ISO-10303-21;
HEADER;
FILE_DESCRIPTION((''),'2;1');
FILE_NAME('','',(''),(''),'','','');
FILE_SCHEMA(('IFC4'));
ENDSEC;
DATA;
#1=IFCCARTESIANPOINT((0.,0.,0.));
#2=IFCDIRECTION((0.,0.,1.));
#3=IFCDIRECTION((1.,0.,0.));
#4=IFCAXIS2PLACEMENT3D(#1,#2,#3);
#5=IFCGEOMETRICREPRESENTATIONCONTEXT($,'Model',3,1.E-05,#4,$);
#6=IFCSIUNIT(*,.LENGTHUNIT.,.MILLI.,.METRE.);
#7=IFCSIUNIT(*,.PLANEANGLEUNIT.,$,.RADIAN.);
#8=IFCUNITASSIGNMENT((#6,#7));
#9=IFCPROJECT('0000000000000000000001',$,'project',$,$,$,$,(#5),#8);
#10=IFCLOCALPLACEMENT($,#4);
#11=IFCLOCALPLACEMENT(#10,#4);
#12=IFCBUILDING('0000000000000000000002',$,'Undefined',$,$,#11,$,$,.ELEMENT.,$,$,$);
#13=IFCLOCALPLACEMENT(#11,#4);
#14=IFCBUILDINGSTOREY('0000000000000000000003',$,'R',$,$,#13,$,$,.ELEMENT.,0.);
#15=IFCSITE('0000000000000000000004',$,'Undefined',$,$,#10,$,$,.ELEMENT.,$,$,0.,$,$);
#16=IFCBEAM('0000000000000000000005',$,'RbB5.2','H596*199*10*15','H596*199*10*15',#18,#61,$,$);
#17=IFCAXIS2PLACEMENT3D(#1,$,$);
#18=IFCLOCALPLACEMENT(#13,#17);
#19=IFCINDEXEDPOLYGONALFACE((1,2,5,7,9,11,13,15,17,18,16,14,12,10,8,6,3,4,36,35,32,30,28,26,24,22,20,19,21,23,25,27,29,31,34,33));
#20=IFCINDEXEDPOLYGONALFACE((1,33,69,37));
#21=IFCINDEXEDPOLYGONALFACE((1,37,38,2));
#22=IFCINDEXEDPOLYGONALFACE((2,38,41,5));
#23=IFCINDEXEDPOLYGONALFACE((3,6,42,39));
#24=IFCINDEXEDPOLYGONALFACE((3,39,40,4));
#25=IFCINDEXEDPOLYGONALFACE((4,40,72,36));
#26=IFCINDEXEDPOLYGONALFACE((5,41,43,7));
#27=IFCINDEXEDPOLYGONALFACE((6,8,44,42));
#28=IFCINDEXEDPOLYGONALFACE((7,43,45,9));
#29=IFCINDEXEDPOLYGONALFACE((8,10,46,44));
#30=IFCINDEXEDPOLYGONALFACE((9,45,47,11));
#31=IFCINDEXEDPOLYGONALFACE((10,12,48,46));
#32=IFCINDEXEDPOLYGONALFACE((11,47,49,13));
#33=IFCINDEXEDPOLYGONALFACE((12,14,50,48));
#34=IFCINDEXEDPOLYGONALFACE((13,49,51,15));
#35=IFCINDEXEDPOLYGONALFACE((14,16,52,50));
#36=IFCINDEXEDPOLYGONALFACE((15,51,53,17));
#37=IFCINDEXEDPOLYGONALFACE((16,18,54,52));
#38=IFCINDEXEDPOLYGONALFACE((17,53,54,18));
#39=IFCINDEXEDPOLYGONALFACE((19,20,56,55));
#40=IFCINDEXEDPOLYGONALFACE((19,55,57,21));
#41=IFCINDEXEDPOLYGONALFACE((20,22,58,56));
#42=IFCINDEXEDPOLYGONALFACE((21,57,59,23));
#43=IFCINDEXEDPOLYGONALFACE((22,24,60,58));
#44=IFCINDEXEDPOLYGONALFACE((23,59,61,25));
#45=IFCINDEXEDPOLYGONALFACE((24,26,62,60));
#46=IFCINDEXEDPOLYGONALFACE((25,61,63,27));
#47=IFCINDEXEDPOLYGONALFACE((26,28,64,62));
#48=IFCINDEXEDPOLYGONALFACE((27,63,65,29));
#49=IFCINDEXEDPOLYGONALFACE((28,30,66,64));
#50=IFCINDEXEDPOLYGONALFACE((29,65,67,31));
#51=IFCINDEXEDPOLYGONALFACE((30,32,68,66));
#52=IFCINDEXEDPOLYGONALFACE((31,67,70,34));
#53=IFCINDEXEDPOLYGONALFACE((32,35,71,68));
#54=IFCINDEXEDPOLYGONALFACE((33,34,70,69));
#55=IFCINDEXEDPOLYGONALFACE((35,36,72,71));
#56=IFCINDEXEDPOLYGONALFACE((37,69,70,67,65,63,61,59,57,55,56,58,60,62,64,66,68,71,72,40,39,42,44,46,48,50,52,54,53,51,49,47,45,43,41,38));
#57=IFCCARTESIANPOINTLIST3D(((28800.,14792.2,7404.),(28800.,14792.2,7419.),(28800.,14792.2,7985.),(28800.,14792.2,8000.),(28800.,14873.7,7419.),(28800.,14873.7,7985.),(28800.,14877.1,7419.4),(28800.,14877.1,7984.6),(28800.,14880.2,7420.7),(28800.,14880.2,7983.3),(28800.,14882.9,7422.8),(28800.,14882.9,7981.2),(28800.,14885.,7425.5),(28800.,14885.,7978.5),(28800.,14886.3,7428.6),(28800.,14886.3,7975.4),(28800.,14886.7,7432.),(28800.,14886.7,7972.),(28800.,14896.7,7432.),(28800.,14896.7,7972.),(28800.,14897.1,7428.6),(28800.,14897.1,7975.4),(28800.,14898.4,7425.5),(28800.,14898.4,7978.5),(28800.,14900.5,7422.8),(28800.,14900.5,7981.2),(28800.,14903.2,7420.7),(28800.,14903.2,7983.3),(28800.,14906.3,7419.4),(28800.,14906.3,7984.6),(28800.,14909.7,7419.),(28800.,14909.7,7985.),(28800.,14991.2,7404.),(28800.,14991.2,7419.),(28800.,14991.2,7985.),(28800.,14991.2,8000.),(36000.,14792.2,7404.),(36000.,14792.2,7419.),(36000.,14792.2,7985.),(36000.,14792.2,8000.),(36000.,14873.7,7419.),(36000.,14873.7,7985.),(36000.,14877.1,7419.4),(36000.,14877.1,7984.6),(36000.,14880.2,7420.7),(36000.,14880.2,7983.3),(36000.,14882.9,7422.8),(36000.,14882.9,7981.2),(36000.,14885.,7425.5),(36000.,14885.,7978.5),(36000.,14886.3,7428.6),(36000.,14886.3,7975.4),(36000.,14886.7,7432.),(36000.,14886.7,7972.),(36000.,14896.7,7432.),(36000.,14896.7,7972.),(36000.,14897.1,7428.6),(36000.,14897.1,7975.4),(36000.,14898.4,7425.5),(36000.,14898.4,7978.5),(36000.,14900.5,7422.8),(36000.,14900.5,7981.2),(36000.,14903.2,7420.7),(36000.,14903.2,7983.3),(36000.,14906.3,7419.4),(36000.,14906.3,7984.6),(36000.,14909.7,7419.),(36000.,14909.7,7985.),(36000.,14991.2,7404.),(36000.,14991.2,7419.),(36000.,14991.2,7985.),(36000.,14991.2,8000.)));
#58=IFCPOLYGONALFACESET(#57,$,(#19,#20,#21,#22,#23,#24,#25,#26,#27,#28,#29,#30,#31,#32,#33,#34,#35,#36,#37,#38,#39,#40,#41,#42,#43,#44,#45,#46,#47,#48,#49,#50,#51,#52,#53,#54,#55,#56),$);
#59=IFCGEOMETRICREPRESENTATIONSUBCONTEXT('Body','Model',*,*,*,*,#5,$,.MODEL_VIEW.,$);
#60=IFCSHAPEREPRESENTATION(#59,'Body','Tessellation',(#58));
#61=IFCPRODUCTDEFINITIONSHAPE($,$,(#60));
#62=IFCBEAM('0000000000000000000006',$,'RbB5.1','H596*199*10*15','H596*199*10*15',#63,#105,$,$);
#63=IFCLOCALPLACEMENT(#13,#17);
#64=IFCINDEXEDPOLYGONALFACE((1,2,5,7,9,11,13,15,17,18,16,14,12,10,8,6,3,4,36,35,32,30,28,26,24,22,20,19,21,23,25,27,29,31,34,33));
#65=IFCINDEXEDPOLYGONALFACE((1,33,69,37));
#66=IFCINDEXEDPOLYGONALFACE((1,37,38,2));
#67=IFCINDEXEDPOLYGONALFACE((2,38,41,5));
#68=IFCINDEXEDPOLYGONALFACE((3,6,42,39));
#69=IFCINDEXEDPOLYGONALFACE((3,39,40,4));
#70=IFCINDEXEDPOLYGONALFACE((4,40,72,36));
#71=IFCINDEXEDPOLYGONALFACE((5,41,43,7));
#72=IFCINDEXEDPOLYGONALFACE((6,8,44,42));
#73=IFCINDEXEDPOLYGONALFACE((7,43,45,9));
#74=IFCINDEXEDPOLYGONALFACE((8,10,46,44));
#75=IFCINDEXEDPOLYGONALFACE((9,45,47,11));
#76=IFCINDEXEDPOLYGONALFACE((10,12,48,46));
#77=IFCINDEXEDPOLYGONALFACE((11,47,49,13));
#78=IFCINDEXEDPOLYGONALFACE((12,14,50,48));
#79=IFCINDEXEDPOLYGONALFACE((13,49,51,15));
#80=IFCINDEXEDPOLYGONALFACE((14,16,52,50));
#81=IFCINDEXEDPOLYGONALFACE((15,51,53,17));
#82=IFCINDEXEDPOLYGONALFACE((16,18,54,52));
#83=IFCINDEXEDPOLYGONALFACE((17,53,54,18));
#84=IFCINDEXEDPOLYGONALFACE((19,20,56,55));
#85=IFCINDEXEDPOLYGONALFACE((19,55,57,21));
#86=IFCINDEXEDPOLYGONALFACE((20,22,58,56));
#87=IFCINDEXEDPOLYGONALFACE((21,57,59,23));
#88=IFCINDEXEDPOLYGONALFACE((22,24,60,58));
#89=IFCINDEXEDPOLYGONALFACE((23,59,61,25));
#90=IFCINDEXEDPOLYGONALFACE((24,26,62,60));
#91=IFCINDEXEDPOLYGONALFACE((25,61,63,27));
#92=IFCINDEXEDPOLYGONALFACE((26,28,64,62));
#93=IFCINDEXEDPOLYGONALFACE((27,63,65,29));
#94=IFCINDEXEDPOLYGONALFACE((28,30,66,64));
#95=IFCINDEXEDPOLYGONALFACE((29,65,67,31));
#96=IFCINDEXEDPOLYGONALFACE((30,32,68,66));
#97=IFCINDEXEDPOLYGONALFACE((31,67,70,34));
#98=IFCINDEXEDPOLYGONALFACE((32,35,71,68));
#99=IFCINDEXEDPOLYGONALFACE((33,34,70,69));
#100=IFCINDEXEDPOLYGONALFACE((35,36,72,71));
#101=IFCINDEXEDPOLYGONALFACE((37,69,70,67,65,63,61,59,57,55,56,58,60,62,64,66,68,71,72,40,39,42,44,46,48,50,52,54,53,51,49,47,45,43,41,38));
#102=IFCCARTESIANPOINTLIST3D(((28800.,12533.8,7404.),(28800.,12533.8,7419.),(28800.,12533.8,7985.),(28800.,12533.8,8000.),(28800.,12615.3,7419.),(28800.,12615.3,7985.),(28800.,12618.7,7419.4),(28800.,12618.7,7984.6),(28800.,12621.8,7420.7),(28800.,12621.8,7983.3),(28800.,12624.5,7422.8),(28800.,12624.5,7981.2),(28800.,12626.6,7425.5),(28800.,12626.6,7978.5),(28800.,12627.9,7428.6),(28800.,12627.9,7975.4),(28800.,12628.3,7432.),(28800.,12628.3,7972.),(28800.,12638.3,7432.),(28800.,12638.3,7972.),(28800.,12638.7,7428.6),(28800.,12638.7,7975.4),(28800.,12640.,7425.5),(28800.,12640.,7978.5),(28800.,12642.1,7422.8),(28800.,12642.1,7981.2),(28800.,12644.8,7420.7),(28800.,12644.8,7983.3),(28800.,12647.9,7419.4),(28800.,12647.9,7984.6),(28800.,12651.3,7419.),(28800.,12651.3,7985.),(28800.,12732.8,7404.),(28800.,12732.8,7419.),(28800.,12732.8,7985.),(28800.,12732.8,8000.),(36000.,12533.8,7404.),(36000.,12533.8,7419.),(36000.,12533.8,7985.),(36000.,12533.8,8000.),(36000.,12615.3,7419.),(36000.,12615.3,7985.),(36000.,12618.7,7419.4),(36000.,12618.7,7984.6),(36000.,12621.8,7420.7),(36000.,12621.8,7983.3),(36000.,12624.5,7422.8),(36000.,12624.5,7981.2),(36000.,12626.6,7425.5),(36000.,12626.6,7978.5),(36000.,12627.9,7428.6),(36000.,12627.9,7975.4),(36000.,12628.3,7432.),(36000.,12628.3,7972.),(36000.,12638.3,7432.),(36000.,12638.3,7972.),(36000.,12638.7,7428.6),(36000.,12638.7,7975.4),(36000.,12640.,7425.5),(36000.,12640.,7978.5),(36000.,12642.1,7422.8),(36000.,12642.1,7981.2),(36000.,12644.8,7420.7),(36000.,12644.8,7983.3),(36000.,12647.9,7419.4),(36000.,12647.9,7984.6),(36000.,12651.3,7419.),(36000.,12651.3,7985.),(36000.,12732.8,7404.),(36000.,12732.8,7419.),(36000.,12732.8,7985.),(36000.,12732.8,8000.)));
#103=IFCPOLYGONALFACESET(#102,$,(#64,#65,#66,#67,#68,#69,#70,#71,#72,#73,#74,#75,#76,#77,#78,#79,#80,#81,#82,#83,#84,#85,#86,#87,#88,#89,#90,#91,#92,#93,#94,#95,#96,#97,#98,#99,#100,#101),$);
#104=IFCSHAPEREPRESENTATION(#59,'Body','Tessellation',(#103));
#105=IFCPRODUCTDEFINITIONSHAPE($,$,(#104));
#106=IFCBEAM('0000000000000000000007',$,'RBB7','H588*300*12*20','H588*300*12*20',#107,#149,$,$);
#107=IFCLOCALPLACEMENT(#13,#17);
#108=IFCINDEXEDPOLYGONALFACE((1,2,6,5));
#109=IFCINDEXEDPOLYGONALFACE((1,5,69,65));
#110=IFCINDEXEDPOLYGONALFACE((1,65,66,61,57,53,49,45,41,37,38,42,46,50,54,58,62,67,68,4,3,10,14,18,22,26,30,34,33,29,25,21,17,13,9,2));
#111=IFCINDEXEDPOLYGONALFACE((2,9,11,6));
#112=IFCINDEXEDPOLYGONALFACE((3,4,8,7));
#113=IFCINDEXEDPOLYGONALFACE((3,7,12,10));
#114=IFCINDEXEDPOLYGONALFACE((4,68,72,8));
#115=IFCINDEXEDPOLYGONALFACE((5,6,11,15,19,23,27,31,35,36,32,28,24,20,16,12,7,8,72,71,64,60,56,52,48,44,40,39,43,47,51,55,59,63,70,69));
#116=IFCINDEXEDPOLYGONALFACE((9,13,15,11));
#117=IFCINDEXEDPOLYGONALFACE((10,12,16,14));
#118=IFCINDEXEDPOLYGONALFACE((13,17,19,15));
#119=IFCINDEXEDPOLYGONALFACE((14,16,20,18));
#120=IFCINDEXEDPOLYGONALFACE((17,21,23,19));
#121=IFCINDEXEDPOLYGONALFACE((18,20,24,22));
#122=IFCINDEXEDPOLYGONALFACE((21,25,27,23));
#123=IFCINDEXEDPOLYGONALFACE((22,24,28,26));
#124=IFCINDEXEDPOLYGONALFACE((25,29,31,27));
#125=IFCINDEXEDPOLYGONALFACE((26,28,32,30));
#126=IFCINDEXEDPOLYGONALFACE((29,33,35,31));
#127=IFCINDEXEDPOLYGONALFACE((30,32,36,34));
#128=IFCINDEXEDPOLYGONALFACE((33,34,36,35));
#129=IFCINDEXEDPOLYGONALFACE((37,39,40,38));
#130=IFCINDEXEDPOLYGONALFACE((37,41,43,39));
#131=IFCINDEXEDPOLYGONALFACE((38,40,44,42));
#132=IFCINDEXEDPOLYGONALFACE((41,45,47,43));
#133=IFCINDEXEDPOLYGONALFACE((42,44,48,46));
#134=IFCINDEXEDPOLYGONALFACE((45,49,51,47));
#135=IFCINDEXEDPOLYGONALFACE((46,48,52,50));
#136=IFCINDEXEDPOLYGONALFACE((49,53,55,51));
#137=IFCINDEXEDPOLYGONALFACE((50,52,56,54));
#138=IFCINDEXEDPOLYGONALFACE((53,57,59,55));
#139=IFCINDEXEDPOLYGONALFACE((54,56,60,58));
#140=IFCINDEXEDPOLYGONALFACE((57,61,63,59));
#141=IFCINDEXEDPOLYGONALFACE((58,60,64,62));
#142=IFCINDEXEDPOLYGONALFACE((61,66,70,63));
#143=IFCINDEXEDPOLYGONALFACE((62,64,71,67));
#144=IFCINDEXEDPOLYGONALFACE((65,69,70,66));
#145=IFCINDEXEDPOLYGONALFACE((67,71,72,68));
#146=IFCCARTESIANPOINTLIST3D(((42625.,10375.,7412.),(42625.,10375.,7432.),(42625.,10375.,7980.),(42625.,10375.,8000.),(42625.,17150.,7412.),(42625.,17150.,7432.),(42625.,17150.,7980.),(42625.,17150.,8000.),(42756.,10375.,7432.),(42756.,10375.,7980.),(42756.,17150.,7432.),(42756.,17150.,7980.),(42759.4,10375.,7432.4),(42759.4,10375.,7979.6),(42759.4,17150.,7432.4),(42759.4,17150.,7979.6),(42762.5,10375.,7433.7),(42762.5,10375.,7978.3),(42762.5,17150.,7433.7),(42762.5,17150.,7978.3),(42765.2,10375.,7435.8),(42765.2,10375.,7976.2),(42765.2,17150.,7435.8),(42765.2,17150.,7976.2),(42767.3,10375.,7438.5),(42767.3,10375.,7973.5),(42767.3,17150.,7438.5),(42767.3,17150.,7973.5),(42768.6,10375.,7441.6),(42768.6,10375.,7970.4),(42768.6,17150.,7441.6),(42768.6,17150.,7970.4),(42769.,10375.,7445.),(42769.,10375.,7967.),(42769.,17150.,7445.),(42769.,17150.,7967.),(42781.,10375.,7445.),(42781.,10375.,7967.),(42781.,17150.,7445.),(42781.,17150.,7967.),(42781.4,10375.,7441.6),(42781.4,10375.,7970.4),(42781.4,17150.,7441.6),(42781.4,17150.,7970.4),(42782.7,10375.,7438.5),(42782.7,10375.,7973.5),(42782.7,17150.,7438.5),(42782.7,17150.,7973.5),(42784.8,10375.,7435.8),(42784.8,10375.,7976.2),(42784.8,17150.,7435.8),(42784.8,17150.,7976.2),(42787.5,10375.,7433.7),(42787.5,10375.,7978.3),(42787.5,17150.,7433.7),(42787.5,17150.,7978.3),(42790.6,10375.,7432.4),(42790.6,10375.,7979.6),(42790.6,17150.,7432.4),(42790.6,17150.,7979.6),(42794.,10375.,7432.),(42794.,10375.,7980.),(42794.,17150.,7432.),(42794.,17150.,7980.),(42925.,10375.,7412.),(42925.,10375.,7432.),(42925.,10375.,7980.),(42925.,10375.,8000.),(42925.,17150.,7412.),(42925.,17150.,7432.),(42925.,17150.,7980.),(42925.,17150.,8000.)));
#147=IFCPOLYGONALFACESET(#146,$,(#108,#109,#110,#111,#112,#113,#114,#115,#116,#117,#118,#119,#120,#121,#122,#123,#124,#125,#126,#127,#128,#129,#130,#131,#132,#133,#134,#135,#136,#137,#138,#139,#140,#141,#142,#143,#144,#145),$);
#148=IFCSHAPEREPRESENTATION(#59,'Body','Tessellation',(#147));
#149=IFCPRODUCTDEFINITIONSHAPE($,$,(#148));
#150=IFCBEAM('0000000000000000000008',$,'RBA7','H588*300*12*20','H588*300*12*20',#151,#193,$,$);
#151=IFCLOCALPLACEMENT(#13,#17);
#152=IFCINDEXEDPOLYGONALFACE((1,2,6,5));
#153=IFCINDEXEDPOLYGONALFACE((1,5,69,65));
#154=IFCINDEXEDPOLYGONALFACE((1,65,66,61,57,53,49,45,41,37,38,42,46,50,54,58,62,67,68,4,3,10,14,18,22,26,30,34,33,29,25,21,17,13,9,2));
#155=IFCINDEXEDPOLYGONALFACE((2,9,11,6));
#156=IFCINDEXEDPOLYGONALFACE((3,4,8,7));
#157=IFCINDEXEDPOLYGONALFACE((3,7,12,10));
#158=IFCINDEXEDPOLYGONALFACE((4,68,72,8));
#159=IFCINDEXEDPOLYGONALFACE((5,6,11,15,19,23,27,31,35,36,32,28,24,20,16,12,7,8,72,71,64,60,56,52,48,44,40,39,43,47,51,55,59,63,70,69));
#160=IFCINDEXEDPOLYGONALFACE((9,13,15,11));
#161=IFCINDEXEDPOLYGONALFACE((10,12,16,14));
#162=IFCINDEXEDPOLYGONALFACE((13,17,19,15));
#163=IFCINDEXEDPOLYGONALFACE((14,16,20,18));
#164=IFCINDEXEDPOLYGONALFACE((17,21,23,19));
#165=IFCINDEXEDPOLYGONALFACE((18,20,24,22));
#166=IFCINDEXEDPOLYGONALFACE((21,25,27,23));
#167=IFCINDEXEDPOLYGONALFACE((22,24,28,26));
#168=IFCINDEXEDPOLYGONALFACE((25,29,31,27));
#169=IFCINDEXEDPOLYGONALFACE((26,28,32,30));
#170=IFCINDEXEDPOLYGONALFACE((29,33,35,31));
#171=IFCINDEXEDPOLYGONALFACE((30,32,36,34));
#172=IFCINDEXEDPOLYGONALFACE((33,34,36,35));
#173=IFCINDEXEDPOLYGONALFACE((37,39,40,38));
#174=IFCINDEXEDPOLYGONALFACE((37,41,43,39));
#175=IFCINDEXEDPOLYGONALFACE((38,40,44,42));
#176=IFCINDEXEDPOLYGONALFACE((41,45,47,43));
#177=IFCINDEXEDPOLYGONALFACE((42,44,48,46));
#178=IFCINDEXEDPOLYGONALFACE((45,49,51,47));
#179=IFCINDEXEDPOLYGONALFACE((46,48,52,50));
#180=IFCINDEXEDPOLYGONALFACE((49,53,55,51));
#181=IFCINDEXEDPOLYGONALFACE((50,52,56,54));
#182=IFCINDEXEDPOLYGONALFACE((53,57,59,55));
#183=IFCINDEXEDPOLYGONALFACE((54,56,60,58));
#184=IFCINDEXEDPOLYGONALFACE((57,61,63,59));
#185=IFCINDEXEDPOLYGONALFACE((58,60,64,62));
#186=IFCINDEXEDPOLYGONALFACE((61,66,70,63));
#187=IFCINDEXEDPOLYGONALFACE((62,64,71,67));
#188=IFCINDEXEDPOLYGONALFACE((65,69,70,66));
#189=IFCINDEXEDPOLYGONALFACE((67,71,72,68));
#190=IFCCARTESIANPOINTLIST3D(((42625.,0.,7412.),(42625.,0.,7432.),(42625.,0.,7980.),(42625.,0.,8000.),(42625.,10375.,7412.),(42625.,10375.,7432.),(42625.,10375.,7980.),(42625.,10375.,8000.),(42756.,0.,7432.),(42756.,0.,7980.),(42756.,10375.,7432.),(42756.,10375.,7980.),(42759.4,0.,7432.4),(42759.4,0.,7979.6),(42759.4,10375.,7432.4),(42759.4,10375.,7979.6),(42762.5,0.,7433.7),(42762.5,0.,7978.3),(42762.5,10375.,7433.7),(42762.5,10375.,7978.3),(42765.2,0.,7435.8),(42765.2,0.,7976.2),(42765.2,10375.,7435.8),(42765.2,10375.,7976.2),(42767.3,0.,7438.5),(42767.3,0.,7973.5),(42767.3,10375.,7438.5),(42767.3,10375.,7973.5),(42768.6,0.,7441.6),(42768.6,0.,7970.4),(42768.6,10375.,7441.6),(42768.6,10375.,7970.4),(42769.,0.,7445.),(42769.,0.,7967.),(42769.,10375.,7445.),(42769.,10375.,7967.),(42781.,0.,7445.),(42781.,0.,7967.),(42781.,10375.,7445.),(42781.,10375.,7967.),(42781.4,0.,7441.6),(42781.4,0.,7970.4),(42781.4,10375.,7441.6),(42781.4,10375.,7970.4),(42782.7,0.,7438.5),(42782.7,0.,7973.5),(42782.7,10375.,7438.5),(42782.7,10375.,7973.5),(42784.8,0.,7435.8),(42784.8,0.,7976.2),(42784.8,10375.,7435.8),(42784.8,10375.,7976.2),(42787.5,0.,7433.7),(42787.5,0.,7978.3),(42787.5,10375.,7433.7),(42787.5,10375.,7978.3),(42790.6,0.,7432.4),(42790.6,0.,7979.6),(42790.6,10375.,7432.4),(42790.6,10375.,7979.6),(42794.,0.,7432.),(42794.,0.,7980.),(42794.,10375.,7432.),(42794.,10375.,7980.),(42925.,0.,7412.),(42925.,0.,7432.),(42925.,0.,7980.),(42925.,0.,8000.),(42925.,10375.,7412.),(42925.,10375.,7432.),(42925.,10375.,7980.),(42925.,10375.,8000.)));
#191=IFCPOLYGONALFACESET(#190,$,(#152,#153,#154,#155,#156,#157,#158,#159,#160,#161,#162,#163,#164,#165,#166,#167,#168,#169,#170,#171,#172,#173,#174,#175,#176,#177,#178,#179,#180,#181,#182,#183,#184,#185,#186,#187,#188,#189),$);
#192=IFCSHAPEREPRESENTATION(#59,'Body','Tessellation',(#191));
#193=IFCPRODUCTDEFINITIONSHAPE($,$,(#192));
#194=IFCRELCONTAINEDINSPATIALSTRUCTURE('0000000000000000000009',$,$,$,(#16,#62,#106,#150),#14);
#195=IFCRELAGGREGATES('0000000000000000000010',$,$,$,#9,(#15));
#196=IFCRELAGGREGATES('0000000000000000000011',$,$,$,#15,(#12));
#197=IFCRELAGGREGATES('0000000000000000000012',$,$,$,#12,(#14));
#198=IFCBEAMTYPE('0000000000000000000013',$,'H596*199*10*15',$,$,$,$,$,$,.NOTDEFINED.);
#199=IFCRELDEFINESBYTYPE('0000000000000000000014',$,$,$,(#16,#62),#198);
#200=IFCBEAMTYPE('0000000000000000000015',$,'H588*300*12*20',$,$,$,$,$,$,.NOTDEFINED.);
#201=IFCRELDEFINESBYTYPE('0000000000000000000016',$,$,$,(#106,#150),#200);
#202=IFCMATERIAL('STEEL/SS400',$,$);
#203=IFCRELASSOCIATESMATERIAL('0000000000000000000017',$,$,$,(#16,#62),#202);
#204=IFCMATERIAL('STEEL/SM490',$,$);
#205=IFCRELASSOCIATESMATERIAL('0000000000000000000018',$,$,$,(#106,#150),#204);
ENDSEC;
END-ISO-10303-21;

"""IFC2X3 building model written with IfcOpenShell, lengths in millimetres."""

from ifc_helpers import new_model, si_unit, frame, origin_with_axes, origin_2d_with_axis, place, context, subcontext, project, spatial, i_section, extrude, material, type_object, element, save


model = new_model("IFC2X3")

# Units and contexts
model_context = context("Model", 3, precision=1e-05, world=origin_with_axes())
body_context = subcontext(model_context, "Body", "Model", "MODEL_VIEW")
ifc_project = project(units=[si_unit("LENGTHUNIT", "METRE", prefix="MILLI"), si_unit("PLANEANGLEUNIT", "RADIAN")], contexts=[model_context])

# Site, building, storey
site_placement = place(None, origin_with_axes())
site = spatial("IfcSite", under=ifc_project, at=site_placement, Name="Undefined", CompositionType="ELEMENT", RefElevation=0.0)
building_placement = place(site_placement, origin_with_axes())
building = spatial("IfcBuilding", under=site, at=building_placement, Name="Undefined", CompositionType="ELEMENT")
storey_placement = place(building_placement, origin_with_axes())
storey = spatial("IfcBuildingStorey", under=building, at=storey_placement, Name="R", CompositionType="ELEMENT", Elevation=0.0)

# Beams
ifc_material_1 = material(Name="STEEL/SS400")
beam_type_1 = type_object("IfcBeamType", Name="H596*199*10*15", PredefinedType="NOTDEFINED")
for number, where, z_axis, x_axis, name in (
    (1, (28800.0, 14891.7, 7702.0), (0.0, 0.0, 1.0), (1.0, 0.0, 0.0), "RbB5.2"),
    (2, (28800.0, 12633.3, 7702.0), (0.0, 0.0, 1.0), (1.0, 0.0, 0.0), "RbB5.1"),
):
    element("IfcBeam", number, at=place(storey_placement, frame(where, z_axis=z_axis, x_axis=x_axis)), inside=storey, type_object=beam_type_1, material=ifc_material_1, Name=name, Description="H596*199*10*15", ObjectType="H596*199*10*15", context=body_context, shape_type="SweptSolid", body=[
        extrude(i_section(OverallWidth=199.0, OverallDepth=596.0, WebThickness=10.0, FlangeThickness=15.0, FilletRadius=13.0, at=origin_2d_with_axis()), frame((7200.0, 0.0, 0.0), z_axis=(-1.0, 0.0, 0.0), x_axis=(0.0, -1.0, 0.0)), (0.0, 0.0, 1.0), 7200.0),
    ])
ifc_material_2 = material(Name="STEEL/SM490")
beam_type_2 = type_object("IfcBeamType", Name="H588*300*12*20", PredefinedType="NOTDEFINED")
beam_1_placement = place(storey_placement, frame((42775.0, 10375.0, 7706.0), z_axis=(0.0, 0.0, 1.0), x_axis=(0.0, 1.0, 0.0)))
element("IfcBeam", 3, at=beam_1_placement, inside=storey, type_object=beam_type_2, material=ifc_material_2, Name="RBB7", Description="H588*300*12*20", ObjectType="H588*300*12*20", context=body_context, shape_type="SweptSolid", body=[
    extrude(i_section(OverallWidth=300.0, OverallDepth=588.0, WebThickness=12.0, FlangeThickness=20.0, FilletRadius=13.0, at=origin_2d_with_axis()), frame((6775.0, 0.0, 0.0), z_axis=(-1.0, 0.0, 0.0), x_axis=(0.0, -1.0, 0.0)), (0.0, 0.0, 1.0), 6775.0),
])
beam_2_placement = place(storey_placement, frame((42775.0, 0.0, 7706.0), z_axis=(0.0, 0.0, 1.0), x_axis=(0.0, 1.0, 0.0)))
element("IfcBeam", 4, at=beam_2_placement, inside=storey, type_object=beam_type_2, material=ifc_material_2, Name="RBA7", Description="H588*300*12*20", ObjectType="H588*300*12*20", context=body_context, shape_type="SweptSolid", body=[
    extrude(i_section(OverallWidth=300.0, OverallDepth=588.0, WebThickness=12.0, FlangeThickness=20.0, FilletRadius=13.0, at=origin_2d_with_axis()), frame((10375.0, 0.0, 0.0), z_axis=(-1.0, 0.0, 0.0), x_axis=(0.0, -1.0, 0.0)), (0.0, 0.0, 1.0), 10375.0),
])

save(model, "model.ifc")
